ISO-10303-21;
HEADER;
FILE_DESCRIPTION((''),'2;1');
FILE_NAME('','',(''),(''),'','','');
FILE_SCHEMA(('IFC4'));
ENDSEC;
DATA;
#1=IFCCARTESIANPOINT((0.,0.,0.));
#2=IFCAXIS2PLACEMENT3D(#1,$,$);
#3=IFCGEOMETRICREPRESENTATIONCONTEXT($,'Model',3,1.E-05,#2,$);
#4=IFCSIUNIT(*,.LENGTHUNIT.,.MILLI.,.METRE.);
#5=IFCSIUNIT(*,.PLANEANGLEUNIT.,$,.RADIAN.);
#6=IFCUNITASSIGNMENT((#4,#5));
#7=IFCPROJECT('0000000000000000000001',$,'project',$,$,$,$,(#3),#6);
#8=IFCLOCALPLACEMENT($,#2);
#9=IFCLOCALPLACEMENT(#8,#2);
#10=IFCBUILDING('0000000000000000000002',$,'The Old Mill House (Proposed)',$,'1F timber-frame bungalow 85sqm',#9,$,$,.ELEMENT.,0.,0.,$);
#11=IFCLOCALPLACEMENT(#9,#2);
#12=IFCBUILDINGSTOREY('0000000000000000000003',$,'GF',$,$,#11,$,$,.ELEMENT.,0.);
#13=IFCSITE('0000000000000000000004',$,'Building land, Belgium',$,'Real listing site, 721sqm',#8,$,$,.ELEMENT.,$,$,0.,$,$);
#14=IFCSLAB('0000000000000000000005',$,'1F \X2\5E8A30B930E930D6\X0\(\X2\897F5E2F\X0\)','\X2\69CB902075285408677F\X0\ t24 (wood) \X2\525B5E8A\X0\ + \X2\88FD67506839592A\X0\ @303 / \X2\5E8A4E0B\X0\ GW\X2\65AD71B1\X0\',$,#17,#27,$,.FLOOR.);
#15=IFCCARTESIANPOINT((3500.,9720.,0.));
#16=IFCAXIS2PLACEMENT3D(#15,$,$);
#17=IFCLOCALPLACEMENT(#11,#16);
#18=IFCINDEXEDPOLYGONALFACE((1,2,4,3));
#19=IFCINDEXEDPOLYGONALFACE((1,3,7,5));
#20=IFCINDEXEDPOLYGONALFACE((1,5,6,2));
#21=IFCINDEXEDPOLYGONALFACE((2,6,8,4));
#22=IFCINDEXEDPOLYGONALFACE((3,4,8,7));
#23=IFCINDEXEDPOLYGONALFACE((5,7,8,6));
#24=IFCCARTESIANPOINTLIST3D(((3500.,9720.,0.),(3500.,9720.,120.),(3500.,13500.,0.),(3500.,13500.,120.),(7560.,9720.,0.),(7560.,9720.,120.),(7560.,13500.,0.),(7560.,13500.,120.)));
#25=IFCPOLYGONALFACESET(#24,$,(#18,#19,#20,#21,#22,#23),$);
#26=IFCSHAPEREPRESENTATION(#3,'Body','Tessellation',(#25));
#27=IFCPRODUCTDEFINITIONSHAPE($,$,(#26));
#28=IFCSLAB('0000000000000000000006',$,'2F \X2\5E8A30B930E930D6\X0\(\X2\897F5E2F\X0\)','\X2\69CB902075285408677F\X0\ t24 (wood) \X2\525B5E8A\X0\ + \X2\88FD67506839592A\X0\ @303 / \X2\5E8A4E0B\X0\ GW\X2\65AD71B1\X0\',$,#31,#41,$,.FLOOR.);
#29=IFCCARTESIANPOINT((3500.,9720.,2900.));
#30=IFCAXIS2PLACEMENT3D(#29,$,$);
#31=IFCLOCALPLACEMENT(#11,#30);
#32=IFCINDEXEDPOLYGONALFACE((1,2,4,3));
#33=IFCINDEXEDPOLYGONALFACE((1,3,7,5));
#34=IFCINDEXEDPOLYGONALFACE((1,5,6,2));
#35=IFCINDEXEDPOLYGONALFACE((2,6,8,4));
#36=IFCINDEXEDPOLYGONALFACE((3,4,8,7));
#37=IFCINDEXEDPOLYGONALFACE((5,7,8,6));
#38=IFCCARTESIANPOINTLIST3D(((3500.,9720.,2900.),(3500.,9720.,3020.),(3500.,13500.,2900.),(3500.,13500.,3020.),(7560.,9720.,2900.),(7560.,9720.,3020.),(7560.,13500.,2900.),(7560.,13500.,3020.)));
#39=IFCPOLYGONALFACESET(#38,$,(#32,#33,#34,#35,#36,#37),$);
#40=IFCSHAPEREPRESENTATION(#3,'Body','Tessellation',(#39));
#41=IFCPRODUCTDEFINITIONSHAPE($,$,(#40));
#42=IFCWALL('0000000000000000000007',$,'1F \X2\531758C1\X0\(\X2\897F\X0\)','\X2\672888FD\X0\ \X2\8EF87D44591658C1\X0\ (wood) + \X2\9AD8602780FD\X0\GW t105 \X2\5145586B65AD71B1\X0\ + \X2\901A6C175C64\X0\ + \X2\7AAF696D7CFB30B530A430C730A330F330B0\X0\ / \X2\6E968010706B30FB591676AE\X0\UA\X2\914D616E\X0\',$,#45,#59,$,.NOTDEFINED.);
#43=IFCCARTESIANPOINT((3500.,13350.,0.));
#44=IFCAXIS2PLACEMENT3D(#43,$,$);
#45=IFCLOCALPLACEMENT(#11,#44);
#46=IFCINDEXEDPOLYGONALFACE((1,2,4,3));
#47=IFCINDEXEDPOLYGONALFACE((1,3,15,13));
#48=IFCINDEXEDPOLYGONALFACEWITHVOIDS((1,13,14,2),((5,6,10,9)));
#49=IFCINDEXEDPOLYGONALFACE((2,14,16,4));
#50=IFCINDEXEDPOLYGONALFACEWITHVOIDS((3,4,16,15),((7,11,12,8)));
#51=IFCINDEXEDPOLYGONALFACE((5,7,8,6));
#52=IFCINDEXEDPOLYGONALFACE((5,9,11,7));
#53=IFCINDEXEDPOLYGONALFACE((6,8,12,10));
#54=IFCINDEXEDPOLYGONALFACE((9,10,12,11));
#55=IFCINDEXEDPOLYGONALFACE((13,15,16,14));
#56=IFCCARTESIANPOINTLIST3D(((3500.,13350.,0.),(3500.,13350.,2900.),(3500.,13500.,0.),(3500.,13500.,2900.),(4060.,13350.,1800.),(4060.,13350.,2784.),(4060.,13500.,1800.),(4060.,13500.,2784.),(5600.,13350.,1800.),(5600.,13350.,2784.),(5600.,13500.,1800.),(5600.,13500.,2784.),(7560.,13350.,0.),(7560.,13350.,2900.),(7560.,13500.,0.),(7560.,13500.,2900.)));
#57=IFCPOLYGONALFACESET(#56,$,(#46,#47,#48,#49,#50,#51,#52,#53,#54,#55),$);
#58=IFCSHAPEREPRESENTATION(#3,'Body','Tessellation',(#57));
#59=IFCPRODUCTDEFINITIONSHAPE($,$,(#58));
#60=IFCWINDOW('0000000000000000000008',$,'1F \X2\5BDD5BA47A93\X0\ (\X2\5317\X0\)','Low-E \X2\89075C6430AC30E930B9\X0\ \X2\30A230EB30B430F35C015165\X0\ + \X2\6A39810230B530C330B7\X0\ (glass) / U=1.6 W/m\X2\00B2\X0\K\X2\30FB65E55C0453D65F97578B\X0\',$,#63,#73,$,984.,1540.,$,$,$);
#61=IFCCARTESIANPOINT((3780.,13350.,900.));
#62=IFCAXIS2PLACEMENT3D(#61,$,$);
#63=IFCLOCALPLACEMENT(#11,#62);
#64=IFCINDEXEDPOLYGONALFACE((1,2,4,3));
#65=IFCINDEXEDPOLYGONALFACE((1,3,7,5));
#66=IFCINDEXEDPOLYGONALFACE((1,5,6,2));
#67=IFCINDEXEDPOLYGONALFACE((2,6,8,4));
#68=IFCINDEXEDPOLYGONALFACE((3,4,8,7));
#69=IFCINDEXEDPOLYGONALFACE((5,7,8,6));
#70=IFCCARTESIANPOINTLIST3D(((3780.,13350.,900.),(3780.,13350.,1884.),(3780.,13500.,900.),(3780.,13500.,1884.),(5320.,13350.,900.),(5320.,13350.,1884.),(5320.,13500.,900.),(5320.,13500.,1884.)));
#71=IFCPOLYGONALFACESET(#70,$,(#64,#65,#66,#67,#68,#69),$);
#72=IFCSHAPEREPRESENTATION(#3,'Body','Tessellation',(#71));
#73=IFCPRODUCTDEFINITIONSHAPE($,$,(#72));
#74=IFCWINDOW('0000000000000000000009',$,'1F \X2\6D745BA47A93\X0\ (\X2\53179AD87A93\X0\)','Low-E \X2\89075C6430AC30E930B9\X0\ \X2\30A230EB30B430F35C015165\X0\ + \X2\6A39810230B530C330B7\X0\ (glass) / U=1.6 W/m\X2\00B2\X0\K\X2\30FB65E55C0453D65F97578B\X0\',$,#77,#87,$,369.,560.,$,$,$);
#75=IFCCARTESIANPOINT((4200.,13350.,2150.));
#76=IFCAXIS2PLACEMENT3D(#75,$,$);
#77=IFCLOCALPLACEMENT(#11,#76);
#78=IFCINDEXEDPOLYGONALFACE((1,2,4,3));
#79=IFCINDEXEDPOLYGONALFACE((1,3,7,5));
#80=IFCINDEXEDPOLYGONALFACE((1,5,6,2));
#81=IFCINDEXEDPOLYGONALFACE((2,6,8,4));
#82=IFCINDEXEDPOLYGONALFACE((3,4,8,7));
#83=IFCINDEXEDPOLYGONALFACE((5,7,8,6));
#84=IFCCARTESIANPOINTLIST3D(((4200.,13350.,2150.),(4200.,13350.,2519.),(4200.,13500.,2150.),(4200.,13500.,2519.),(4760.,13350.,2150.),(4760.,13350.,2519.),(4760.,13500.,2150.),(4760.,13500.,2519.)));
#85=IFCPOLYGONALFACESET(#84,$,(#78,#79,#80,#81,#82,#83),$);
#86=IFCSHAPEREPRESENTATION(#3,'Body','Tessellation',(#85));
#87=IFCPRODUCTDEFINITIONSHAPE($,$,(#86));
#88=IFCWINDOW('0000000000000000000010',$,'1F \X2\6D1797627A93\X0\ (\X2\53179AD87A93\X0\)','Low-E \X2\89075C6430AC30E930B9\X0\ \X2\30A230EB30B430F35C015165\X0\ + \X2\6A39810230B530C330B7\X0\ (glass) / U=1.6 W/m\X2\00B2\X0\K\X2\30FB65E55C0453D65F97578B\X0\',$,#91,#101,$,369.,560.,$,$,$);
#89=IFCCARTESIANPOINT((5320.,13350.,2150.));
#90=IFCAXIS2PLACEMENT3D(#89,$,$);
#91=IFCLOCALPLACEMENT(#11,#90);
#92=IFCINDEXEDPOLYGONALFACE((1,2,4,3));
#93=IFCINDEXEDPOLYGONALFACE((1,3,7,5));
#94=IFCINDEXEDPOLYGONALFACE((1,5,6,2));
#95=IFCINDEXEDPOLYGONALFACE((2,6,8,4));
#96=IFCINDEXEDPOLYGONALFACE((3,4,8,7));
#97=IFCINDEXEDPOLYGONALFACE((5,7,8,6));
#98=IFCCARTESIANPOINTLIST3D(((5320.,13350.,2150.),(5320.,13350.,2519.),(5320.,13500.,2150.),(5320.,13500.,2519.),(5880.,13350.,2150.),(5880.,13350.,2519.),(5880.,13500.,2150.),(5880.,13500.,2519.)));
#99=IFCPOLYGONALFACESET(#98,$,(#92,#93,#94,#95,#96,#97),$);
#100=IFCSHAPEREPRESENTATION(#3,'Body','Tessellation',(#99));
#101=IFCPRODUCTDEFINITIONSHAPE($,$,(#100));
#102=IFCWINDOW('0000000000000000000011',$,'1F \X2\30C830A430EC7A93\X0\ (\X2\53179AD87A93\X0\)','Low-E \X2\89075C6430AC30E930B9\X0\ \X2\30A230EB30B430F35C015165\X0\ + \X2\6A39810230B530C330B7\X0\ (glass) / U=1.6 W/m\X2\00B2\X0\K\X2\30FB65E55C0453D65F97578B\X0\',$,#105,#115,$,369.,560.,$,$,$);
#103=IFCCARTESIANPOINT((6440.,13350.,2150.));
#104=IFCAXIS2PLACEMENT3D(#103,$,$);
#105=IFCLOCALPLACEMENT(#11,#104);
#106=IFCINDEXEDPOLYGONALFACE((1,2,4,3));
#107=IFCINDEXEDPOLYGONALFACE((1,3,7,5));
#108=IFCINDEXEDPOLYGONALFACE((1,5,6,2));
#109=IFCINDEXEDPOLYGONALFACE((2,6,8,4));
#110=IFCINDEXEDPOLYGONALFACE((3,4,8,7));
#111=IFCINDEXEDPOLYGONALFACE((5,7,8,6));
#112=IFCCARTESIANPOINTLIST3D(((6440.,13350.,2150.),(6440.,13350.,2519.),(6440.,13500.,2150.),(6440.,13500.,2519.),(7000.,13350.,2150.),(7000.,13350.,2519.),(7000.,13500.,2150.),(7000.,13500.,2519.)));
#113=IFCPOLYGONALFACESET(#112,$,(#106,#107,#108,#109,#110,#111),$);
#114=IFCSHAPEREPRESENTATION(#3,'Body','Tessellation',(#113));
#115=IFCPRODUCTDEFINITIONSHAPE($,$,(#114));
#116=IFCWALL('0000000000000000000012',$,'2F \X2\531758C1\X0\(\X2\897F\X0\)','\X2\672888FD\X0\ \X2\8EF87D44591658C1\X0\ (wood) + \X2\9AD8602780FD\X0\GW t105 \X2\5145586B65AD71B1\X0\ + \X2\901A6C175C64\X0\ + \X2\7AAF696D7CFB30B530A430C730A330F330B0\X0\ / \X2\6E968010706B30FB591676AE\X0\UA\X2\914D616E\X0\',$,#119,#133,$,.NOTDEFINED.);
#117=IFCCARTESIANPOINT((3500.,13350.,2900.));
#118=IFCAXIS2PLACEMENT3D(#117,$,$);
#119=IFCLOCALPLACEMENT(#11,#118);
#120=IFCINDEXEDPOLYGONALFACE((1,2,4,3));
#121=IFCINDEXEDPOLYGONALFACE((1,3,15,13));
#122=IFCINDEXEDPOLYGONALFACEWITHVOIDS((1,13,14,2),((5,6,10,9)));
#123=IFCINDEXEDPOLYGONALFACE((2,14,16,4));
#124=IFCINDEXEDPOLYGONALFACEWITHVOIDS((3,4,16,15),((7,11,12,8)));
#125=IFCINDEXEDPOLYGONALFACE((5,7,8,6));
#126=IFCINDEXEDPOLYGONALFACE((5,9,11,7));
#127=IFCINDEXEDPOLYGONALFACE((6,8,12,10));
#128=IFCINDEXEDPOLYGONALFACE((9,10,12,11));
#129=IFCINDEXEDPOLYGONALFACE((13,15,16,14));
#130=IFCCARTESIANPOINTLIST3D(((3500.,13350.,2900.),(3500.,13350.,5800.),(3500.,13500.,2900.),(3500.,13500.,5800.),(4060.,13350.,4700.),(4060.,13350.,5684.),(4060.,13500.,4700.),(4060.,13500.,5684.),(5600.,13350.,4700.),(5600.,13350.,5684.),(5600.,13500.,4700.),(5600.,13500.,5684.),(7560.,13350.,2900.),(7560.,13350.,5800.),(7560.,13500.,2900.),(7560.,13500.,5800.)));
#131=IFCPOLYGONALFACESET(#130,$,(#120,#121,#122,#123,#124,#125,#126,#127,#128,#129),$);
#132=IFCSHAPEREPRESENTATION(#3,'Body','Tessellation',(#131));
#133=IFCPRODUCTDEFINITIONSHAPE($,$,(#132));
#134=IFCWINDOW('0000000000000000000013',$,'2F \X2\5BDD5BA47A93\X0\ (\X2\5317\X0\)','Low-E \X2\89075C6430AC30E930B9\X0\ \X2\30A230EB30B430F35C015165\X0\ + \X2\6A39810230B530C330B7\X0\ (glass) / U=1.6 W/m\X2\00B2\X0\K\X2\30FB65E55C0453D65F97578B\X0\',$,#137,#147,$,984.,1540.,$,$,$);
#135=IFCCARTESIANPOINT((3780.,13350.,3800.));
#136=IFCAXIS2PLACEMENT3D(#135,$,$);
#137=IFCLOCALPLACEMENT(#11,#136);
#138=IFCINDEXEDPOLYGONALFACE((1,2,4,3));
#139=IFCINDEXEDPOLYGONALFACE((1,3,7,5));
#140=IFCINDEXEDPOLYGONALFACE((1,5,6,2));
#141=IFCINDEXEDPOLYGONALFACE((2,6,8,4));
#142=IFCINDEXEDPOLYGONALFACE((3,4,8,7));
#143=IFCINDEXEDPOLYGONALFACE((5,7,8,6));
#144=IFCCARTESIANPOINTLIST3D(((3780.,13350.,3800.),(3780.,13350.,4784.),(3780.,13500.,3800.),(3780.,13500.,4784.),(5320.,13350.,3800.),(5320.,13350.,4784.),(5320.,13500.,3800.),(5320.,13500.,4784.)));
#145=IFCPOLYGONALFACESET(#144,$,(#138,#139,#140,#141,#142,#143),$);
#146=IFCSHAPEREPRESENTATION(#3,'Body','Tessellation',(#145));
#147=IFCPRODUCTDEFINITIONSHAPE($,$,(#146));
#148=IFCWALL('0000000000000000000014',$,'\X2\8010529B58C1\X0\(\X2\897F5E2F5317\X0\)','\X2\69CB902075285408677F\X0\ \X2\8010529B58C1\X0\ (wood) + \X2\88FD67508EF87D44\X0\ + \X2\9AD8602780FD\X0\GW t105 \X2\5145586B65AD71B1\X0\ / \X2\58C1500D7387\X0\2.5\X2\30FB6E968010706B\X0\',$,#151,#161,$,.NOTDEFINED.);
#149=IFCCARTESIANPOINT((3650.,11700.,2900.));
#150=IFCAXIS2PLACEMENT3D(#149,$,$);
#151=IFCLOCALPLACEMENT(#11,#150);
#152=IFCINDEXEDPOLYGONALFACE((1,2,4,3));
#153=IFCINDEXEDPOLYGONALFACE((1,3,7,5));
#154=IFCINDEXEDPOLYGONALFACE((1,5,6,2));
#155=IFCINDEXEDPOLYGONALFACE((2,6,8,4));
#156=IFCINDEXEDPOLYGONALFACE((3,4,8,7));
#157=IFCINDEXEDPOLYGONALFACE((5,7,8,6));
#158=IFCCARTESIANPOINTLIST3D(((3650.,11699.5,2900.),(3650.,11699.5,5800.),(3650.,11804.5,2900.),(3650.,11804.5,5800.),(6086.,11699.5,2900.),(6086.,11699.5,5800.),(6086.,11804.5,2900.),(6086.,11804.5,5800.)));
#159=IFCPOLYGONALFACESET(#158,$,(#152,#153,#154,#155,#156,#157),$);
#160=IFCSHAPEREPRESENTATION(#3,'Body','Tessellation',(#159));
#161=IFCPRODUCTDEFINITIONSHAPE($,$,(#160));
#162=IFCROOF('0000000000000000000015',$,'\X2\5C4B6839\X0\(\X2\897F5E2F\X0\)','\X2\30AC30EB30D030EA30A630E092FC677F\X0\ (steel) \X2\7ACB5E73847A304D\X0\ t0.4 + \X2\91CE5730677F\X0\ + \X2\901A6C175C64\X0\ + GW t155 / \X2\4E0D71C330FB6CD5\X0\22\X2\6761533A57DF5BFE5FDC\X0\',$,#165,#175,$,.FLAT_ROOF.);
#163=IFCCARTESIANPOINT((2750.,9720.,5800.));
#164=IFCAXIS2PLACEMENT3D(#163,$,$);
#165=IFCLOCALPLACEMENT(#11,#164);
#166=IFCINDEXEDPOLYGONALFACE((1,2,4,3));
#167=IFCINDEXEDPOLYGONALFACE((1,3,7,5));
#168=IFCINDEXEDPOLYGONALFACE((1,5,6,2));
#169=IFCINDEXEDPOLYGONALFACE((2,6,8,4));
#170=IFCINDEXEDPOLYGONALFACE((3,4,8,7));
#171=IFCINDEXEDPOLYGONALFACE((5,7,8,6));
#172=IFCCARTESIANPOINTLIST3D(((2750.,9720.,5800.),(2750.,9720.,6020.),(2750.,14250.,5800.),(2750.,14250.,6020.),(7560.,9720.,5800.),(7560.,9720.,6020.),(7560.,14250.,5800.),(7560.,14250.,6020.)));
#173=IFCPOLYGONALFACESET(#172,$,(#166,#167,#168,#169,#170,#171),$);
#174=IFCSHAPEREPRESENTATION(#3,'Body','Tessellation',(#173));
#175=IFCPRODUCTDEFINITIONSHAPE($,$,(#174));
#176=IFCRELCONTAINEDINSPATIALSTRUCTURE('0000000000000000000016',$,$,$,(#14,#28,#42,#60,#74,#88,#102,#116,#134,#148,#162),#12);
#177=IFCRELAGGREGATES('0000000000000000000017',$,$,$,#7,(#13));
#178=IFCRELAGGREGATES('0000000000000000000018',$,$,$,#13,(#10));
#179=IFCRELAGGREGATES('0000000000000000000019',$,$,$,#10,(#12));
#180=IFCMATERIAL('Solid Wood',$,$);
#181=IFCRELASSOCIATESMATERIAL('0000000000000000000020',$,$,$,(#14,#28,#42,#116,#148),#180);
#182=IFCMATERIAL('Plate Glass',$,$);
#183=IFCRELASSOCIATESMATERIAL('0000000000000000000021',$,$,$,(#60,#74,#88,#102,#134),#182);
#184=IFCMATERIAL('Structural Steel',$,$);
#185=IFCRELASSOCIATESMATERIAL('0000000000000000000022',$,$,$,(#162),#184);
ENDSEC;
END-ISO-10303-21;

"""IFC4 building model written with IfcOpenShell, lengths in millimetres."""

from ifc_helpers import new_model, si_unit, frame, frame_2d, origin, place, context, project, spatial, rectangle, extrude, material, element, fill, save


model = new_model("IFC4")

# Units and contexts
model_context = context("Model", 3, precision=1e-05, world=origin())
ifc_project = project(units=[si_unit("LENGTHUNIT", "METRE", prefix="MILLI"), si_unit("PLANEANGLEUNIT", "RADIAN")], contexts=[model_context])

# Site, building, storey
site_placement = place(None, origin())
site = spatial("IfcSite", under=ifc_project, at=site_placement, Name="Building land, Belgium", ObjectType="Real listing site, 721sqm", CompositionType="ELEMENT", RefElevation=0.0)
building_placement = place(site_placement, origin())
building = spatial("IfcBuilding", under=site, at=building_placement, Name="The Old Mill House (Proposed)", ObjectType="1F timber-frame bungalow 85sqm", CompositionType="ELEMENT", ElevationOfRefHeight=0.0, ElevationOfTerrain=0.0)
storey_placement = place(building_placement, origin())
storey = spatial("IfcBuildingStorey", under=building, at=storey_placement, Name="GF", CompositionType="ELEMENT", Elevation=0.0)

# Slabs
ifc_material_1 = material(Name="Solid Wood")
slab_1_placement = place(storey_placement, frame((3500.0, 9720.0, 0.0)))
element("IfcSlab", 1, at=slab_1_placement, inside=storey, material=ifc_material_1, Name="1F 床スラブ(西帯)", Description="構造用合板 t24 (wood) 剛床 + 製材根太 @303 / 床下 GW断熱", PredefinedType="FLOOR", context=model_context, shape_type="SweptSolid", body=[
    extrude(rectangle(XDim=4060.0, YDim=3780.0, at=frame_2d((2030.0, 1890.0))), frame((3500.0, 9720.0, 0.0)), (0.0, 0.0, 1.0), 120.0),
])
slab_2_placement = place(storey_placement, frame((3500.0, 9720.0, 2900.0)))
element("IfcSlab", 2, at=slab_2_placement, inside=storey, material=ifc_material_1, Name="2F 床スラブ(西帯)", Description="構造用合板 t24 (wood) 剛床 + 製材根太 @303 / 床下 GW断熱", PredefinedType="FLOOR", context=model_context, shape_type="SweptSolid", body=[
    extrude(rectangle(XDim=4060.0, YDim=3780.0, at=frame_2d((2030.0, 1890.0))), frame((3500.0, 9720.0, 2900.0)), (0.0, 0.0, 1.0), 120.0),
])

# Wall, openings, windows
wall_1_placement = place(storey_placement, frame((3500.0, 13350.0, 0.0)))
wall_1 = element("IfcWall", 3, at=wall_1_placement, inside=storey, material=ifc_material_1, Name="1F 北壁(西)", Description="木製 軸組外壁 (wood) + 高性能GW t105 充填断熱 + 通気層 + 窯業系サイディング / 準耐火・外皮UA配慮", PredefinedType="NOTDEFINED", context=model_context, shape_type="SweptSolid", body=[
    extrude(rectangle(XDim=4060.0, YDim=150.0, at=frame_2d((2030.0, 75.0))), frame((3500.0, 13350.0, 0.0)), (0.0, 0.0, 1.0), 2900.0),
])
opening_1_placement = place(storey_placement, frame((3780.0, 13350.0, 900.0)))
opening_1 = element("IfcOpeningElement", 4, at=opening_1_placement, cuts=wall_1, PredefinedType="NOTDEFINED", context=model_context, shape_type="SweptSolid", body=[
    extrude(rectangle(XDim=1540.0, YDim=150.0, at=frame_2d((770.0, 75.0))), frame((3780.0, 13350.0, 900.0)), (0.0, 0.0, 1.0), 984.0),
])
opening_2_placement = place(storey_placement, frame((4200.0, 13350.0, 2150.0)))
opening_2 = element("IfcOpeningElement", 5, at=opening_2_placement, cuts=wall_1, PredefinedType="NOTDEFINED", context=model_context, shape_type="SweptSolid", body=[
    extrude(rectangle(XDim=560.0, YDim=150.0, at=frame_2d((280.0, 75.0))), frame((4200.0, 13350.0, 2150.0)), (0.0, 0.0, 1.0), 369.0),
])
opening_3_placement = place(storey_placement, frame((5320.0, 13350.0, 2150.0)))
opening_3 = element("IfcOpeningElement", 6, at=opening_3_placement, cuts=wall_1, PredefinedType="NOTDEFINED", context=model_context, shape_type="SweptSolid", body=[
    extrude(rectangle(XDim=560.0, YDim=150.0, at=frame_2d((280.0, 75.0))), frame((5320.0, 13350.0, 2150.0)), (0.0, 0.0, 1.0), 369.0),
])
opening_4_placement = place(storey_placement, frame((6440.0, 13350.0, 2150.0)))
opening_4 = element("IfcOpeningElement", 7, at=opening_4_placement, cuts=wall_1, PredefinedType="NOTDEFINED", context=model_context, shape_type="SweptSolid", body=[
    extrude(rectangle(XDim=560.0, YDim=150.0, at=frame_2d((280.0, 75.0))), frame((6440.0, 13350.0, 2150.0)), (0.0, 0.0, 1.0), 369.0),
])
ifc_material_2 = material(Name="Plate Glass")
window_1_placement = place(storey_placement, frame((3780.0, 13350.0, 900.0)))
window_1 = element("IfcWindow", 8, at=window_1_placement, inside=storey, material=ifc_material_2, Name="1F 寝室窓 (北)", Description="Low-E 複層ガラス アルゴン封入 + 樹脂サッシ (glass) / U=1.6 W/m²K・日射取得型", OverallHeight=984.0, OverallWidth=1540.0, context=model_context, shape_type="SweptSolid", body=[
    extrude(rectangle(XDim=1540.0, YDim=150.0, at=frame_2d((770.0, 75.0))), frame((3780.0, 13350.0, 900.0)), (0.0, 0.0, 1.0), 984.0),
])
fill(opening_1, window_1)
window_2_placement = place(storey_placement, frame((4200.0, 13350.0, 2150.0)))
window_2 = element("IfcWindow", 9, at=window_2_placement, inside=storey, material=ifc_material_2, Name="1F 浴室窓 (北高窓)", Description="Low-E 複層ガラス アルゴン封入 + 樹脂サッシ (glass) / U=1.6 W/m²K・日射取得型", OverallHeight=369.0, OverallWidth=560.0, context=model_context, shape_type="SweptSolid", body=[
    extrude(rectangle(XDim=560.0, YDim=150.0, at=frame_2d((280.0, 75.0))), frame((4200.0, 13350.0, 2150.0)), (0.0, 0.0, 1.0), 369.0),
])
fill(opening_2, window_2)
window_3_placement = place(storey_placement, frame((5320.0, 13350.0, 2150.0)))
window_3 = element("IfcWindow", 10, at=window_3_placement, inside=storey, material=ifc_material_2, Name="1F 洗面窓 (北高窓)", Description="Low-E 複層ガラス アルゴン封入 + 樹脂サッシ (glass) / U=1.6 W/m²K・日射取得型", OverallHeight=369.0, OverallWidth=560.0, context=model_context, shape_type="SweptSolid", body=[
    extrude(rectangle(XDim=560.0, YDim=150.0, at=frame_2d((280.0, 75.0))), frame((5320.0, 13350.0, 2150.0)), (0.0, 0.0, 1.0), 369.0),
])
fill(opening_3, window_3)
window_4_placement = place(storey_placement, frame((6440.0, 13350.0, 2150.0)))
window_4 = element("IfcWindow", 11, at=window_4_placement, inside=storey, material=ifc_material_2, Name="1F トイレ窓 (北高窓)", Description="Low-E 複層ガラス アルゴン封入 + 樹脂サッシ (glass) / U=1.6 W/m²K・日射取得型", OverallHeight=369.0, OverallWidth=560.0, context=model_context, shape_type="SweptSolid", body=[
    extrude(rectangle(XDim=560.0, YDim=150.0, at=frame_2d((280.0, 75.0))), frame((6440.0, 13350.0, 2150.0)), (0.0, 0.0, 1.0), 369.0),
])
fill(opening_4, window_4)

# Wall, opening, window
wall_2_placement = place(storey_placement, frame((3500.0, 13350.0, 2900.0)))
wall_2 = element("IfcWall", 12, at=wall_2_placement, inside=storey, material=ifc_material_1, Name="2F 北壁(西)", Description="木製 軸組外壁 (wood) + 高性能GW t105 充填断熱 + 通気層 + 窯業系サイディング / 準耐火・外皮UA配慮", PredefinedType="NOTDEFINED", context=model_context, shape_type="SweptSolid", body=[
    extrude(rectangle(XDim=4060.0, YDim=150.0, at=frame_2d((2030.0, 75.0))), frame((3500.0, 13350.0, 2900.0)), (0.0, 0.0, 1.0), 2900.0),
])
opening_5_placement = place(storey_placement, frame((3780.0, 13350.0, 3800.0)))
opening_5 = element("IfcOpeningElement", 13, at=opening_5_placement, cuts=wall_2, PredefinedType="NOTDEFINED", context=model_context, shape_type="SweptSolid", body=[
    extrude(rectangle(XDim=1540.0, YDim=150.0, at=frame_2d((770.0, 75.0))), frame((3780.0, 13350.0, 3800.0)), (0.0, 0.0, 1.0), 984.0),
])
window_5_placement = place(storey_placement, frame((3780.0, 13350.0, 3800.0)))
window_5 = element("IfcWindow", 14, at=window_5_placement, inside=storey, material=ifc_material_2, Name="2F 寝室窓 (北)", Description="Low-E 複層ガラス アルゴン封入 + 樹脂サッシ (glass) / U=1.6 W/m²K・日射取得型", OverallHeight=984.0, OverallWidth=1540.0, context=model_context, shape_type="SweptSolid", body=[
    extrude(rectangle(XDim=1540.0, YDim=150.0, at=frame_2d((770.0, 75.0))), frame((3780.0, 13350.0, 3800.0)), (0.0, 0.0, 1.0), 984.0),
])
fill(opening_5, window_5)

# Wall
wall_3_placement = place(storey_placement, frame((3650.0, 11700.0, 2900.0)))
element("IfcWall", 15, at=wall_3_placement, inside=storey, material=ifc_material_1, Name="耐力壁(西帯北)", Description="構造用合板 耐力壁 (wood) + 製材軸組 + 高性能GW t105 充填断熱 / 壁倍率2.5・準耐火", PredefinedType="NOTDEFINED", context=model_context, shape_type="SweptSolid", body=[
    extrude(rectangle(XDim=2436.0, YDim=105.0, at=frame_2d((1218.0, 52.0))), frame((3650.0, 11700.0, 2900.0)), (0.0, 0.0, 1.0), 2900.0),
])

# Roof
ifc_material_3 = material(Name="Structural Steel")
for number, where, name in (
    (16, (2750.0, 9720.0, 5800.0), "屋根(西帯)"),
):
    element("IfcRoof", number, at=place(storey_placement, frame(where)), inside=storey, material=ifc_material_3, Name=name, Description="ガルバリウム鋼板 (steel) 立平葺き t0.4 + 野地板 + 通気層 + GW t155 / 不燃・法22条区域対応", PredefinedType="FLAT_ROOF", context=model_context, shape_type="SweptSolid", body=[
        extrude(rectangle(XDim=4810.0, YDim=4530.0, at=frame_2d((2405.0, 2265.0))), frame((2750.0, 9720.0, 5800.0)), (0.0, 0.0, 1.0), 220.0),
    ])

save(model, "model.ifc")
